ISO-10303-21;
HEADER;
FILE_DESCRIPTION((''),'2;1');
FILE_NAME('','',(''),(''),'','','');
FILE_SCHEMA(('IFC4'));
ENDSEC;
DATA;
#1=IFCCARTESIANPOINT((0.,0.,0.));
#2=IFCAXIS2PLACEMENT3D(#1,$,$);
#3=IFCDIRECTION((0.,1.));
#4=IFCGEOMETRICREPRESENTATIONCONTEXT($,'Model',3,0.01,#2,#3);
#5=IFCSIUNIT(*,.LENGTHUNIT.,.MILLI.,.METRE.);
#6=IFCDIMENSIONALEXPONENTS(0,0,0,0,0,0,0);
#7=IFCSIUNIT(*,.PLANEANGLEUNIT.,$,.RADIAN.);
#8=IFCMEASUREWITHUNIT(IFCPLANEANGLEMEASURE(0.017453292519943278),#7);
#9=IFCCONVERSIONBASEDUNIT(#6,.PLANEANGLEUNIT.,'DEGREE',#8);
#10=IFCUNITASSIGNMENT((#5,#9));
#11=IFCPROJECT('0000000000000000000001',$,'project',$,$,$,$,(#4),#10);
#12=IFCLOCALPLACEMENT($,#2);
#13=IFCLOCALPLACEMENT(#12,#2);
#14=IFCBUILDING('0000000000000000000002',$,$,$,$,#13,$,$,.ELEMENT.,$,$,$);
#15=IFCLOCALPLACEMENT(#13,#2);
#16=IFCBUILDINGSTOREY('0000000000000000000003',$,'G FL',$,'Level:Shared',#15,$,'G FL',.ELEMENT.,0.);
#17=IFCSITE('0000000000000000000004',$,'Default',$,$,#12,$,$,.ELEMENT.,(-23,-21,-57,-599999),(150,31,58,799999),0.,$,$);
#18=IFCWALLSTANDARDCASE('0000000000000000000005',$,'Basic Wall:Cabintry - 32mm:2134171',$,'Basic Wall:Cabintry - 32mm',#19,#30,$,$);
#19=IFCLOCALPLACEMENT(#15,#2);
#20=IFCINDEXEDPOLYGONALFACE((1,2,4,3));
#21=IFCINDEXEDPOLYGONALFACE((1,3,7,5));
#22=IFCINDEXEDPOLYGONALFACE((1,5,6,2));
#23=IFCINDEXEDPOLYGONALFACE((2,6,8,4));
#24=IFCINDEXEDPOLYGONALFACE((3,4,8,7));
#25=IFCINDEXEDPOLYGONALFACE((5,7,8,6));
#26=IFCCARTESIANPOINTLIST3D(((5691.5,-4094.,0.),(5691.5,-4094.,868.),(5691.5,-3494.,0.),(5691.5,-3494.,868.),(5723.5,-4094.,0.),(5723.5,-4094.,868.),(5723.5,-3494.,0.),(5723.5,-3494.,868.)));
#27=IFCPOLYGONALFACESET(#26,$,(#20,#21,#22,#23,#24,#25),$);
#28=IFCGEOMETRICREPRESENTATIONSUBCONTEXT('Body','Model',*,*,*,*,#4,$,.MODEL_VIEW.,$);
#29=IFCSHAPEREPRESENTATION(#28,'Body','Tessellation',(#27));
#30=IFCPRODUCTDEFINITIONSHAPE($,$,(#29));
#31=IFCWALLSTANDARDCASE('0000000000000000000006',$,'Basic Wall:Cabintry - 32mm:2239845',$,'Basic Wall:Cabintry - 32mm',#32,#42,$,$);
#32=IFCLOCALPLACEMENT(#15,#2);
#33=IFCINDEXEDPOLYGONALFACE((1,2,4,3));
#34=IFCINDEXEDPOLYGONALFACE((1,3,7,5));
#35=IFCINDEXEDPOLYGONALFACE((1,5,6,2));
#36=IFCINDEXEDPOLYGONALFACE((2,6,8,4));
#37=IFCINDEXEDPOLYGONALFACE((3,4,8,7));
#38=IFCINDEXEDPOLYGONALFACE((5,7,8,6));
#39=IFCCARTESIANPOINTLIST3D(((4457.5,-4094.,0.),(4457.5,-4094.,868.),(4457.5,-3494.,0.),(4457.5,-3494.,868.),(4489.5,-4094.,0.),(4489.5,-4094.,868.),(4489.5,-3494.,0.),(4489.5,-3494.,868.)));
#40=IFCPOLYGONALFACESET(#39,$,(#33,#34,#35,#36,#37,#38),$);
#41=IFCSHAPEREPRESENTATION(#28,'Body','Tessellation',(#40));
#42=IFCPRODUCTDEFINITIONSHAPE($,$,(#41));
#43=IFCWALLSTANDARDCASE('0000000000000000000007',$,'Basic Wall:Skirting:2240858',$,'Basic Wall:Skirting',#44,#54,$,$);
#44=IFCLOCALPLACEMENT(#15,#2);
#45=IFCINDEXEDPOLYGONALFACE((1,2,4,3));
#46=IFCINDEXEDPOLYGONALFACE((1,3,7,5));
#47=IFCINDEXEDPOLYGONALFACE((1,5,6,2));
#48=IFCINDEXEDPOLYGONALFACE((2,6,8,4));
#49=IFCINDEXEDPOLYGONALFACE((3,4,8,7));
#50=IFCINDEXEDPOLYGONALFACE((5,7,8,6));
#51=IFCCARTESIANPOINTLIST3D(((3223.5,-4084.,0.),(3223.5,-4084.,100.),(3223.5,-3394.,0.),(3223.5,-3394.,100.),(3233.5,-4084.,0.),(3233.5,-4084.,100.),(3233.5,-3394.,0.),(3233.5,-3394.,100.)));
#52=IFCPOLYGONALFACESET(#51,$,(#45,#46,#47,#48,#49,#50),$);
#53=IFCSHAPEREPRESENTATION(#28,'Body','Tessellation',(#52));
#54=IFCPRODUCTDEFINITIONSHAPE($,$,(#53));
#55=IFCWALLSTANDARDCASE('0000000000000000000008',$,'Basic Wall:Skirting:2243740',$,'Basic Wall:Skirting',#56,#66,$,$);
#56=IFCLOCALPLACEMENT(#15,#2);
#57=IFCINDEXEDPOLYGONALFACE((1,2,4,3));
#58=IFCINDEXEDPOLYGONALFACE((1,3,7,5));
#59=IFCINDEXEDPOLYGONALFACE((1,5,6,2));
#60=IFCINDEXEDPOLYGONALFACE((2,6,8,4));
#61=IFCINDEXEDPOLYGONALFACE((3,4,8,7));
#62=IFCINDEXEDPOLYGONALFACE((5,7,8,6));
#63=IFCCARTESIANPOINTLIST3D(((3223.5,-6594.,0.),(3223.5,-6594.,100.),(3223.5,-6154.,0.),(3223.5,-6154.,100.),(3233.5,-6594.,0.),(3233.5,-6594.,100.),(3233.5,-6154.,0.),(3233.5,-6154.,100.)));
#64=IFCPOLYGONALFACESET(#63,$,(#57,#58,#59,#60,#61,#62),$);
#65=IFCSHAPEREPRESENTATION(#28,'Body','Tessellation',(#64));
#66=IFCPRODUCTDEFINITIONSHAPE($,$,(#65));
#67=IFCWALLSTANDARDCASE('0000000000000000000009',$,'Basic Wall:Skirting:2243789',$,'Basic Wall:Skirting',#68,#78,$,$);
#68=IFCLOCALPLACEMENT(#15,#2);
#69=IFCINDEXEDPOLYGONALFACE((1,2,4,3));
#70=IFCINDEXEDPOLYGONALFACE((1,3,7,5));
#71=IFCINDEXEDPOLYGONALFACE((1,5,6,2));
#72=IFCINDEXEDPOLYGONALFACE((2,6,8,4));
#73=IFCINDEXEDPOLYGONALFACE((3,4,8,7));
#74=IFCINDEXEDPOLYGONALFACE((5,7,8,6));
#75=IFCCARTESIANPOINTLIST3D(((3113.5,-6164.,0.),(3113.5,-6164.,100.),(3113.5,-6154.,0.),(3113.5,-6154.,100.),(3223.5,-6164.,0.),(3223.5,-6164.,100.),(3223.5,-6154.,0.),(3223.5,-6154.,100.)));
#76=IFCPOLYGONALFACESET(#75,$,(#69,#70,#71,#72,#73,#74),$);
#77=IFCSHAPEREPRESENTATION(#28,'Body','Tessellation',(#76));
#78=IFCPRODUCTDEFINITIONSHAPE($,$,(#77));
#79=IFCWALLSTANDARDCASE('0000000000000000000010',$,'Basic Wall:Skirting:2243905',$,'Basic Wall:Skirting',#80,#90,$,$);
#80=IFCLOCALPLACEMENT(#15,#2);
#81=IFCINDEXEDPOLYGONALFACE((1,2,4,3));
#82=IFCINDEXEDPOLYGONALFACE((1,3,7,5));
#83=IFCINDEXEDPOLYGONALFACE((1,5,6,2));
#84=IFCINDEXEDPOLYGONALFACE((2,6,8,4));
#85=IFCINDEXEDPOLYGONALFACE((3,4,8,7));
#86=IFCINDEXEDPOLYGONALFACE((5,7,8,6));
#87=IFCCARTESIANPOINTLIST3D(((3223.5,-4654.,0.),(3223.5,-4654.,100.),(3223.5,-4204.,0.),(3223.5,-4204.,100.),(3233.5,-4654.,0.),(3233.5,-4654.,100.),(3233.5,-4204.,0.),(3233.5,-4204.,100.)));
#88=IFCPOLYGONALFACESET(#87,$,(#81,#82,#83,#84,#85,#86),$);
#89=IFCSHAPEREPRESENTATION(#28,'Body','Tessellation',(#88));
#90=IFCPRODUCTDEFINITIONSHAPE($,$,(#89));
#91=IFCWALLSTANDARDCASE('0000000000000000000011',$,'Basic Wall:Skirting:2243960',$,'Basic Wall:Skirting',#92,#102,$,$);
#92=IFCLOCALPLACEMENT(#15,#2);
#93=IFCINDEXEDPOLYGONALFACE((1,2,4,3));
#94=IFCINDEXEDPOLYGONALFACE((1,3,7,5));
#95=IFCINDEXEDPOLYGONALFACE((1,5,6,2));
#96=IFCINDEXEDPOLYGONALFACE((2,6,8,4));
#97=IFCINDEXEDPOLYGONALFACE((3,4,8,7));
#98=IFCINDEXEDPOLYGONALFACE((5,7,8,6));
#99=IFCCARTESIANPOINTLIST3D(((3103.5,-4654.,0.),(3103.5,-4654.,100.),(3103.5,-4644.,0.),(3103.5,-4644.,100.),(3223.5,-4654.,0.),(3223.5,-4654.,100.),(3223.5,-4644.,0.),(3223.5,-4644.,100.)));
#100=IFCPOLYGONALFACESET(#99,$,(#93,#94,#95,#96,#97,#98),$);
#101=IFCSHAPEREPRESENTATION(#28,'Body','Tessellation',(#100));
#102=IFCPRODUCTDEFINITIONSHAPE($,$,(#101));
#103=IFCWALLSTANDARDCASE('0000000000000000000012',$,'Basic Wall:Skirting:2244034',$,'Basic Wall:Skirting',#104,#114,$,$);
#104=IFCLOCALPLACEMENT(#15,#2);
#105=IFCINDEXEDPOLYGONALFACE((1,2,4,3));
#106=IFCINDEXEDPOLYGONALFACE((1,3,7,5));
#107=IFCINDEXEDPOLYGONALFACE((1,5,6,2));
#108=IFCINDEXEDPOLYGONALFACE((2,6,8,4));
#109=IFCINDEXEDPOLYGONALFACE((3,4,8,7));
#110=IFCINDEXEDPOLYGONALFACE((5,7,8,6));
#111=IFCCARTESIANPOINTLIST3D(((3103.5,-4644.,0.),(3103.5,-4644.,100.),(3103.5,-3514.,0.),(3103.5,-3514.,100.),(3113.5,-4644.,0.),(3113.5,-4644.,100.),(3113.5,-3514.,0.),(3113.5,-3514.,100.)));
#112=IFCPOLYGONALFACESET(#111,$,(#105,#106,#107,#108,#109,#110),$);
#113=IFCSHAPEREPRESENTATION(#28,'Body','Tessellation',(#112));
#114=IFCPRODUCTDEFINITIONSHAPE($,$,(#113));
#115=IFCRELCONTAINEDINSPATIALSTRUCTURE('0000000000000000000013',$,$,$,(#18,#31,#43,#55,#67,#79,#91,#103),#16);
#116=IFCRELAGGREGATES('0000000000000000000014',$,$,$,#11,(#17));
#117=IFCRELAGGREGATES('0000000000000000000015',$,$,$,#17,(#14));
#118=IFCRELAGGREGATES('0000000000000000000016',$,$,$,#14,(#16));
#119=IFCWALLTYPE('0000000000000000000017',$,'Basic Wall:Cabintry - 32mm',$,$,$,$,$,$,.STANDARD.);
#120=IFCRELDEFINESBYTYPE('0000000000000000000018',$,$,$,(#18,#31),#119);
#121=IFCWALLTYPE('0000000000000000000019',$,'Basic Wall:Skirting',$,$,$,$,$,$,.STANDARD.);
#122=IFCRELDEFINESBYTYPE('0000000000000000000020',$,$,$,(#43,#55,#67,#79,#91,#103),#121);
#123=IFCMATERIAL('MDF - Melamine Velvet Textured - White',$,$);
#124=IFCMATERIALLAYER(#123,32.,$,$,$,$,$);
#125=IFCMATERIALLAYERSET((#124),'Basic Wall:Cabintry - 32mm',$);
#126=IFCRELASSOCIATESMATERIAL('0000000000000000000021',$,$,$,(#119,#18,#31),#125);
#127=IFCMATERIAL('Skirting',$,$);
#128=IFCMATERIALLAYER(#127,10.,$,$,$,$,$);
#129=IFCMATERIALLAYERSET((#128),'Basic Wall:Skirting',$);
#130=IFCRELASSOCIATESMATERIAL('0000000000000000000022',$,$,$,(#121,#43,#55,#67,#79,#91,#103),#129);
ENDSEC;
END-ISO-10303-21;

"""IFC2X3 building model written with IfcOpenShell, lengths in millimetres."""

from ifc_helpers import new_model, entity, si_unit, converted_unit, direction, frame, frame_2d, origin, place, context, subcontext, project, spatial, polyline, rectangle, extrude, clip, bounded_halfspace, material, layer, layer_set, layer_usage, type_object, element, save


model = new_model("IFC2X3")

# Units and contexts
model_context = context("Model", 3, precision=0.01, world=origin(), true_north=direction((0.0, 1.0)))
body_context = subcontext(model_context, "Body", "Model", "MODEL_VIEW")
ifc_project = project(units=[si_unit("LENGTHUNIT", "METRE", prefix="MILLI"), converted_unit("PLANEANGLEUNIT", "DEGREE", entity("IfcPlaneAngleMeasure", 0.017453292519943278), si_unit("PLANEANGLEUNIT", "RADIAN"), dimensions=[0, 0, 0, 0, 0, 0, 0])], contexts=[model_context])

# Site, building, storey
site_placement = place(None, origin())
site = spatial("IfcSite", under=ifc_project, at=site_placement, Name="Default", CompositionType="ELEMENT", RefLatitude=(-23, -21, -57, -599999), RefLongitude=(150, 31, 58, 799999), RefElevation=0.0)
building_placement = place(site_placement, origin())
building = spatial("IfcBuilding", under=site, at=building_placement, CompositionType="ELEMENT")
storey_placement = place(building_placement, origin())
storey = spatial("IfcBuildingStorey", under=building, at=storey_placement, Name="G FL", ObjectType="Level:Shared", LongName="G FL", CompositionType="ELEMENT", Elevation=0.0)

# Shared definitions
ifc_material_1 = material(Name="MDF - Melamine Velvet Textured - White")

# Walls
ifc_layer_1 = layer(ifc_material_1, 32.0)
ifc_layer_set_1 = layer_set([ifc_layer_1], Name="Basic Wall:Cabintry - 32mm")
ifc_layer_usage_1 = layer_usage(ifc_layer_set_1, "AXIS2", "POSITIVE", -16.0)
wall_type_1 = type_object("IfcWallType", Name="Basic Wall:Cabintry - 32mm", PredefinedType="STANDARD", material=ifc_layer_set_1)
wall_1_placement = place(storey_placement, frame((5707.5, -4094.0, 0.0), z_axis=(0.0, 0.0, 1.0), x_axis=(0.0, 1.0, 0.0)))
element("IfcWallStandardCase", 1, at=wall_1_placement, inside=storey, type_object=wall_type_1, material=ifc_layer_usage_1, Name="Basic Wall:Cabintry - 32mm:2134171", ObjectType="Basic Wall:Cabintry - 32mm", context=body_context, shape_type="Clipping", body=[
    clip(extrude(rectangle(XDim=600.0, YDim=32.0, at=frame_2d((300.0, 0.0), x_axis=(-1.0, 0.0))), origin(), (0.0, 0.0, 1.0), 868.0), bounded_halfspace(frame((0.0, -16.0, 868.0), z_axis=(0.0, 0.0, -1.0), x_axis=(-1.0, 0.0, 0.0)), True, frame((0.0, -16.0, 868.0)), polyline([(0.0, 0.0), (600.0, 0.0), (600.0, 32.0), (0.0, 32.0), (0.0, 0.0)]))),
])
ifc_layer_usage_2 = layer_usage(ifc_layer_set_1, "AXIS2", "POSITIVE", -16.0)
wall_2_placement = place(storey_placement, frame((4473.5, -4094.0, 0.0), z_axis=(0.0, 0.0, 1.0), x_axis=(0.0, 1.0, 0.0)))
element("IfcWallStandardCase", 2, at=wall_2_placement, inside=storey, type_object=wall_type_1, material=ifc_layer_usage_2, Name="Basic Wall:Cabintry - 32mm:2239845", ObjectType="Basic Wall:Cabintry - 32mm", context=body_context, shape_type="Clipping", body=[
    clip(extrude(rectangle(XDim=600.0, YDim=32.0, at=frame_2d((300.0, 0.0), x_axis=(-1.0, 0.0))), origin(), (0.0, 0.0, 1.0), 868.0), bounded_halfspace(frame((0.0, -16.0, 868.0), z_axis=(0.0, 0.0, -1.0), x_axis=(-1.0, 0.0, 0.0)), True, frame((0.0, -16.0, 868.0)), polyline([(0.0, 0.0), (600.0, 0.0), (600.0, 32.0), (0.0, 32.0), (0.0, 0.0)]))),
])
ifc_material_2 = material(Name="Skirting")
ifc_layer_2 = layer(ifc_material_2, 10.0)
ifc_layer_set_2 = layer_set([ifc_layer_2], Name="Basic Wall:Skirting")
ifc_layer_usage_3 = layer_usage(ifc_layer_set_2, "AXIS2", "NEGATIVE", 5.0)
wall_type_2 = type_object("IfcWallType", Name="Basic Wall:Skirting", PredefinedType="STANDARD", material=ifc_layer_set_2)
wall_3_placement = place(storey_placement, frame((3228.5, -4084.0, 0.0), z_axis=(0.0, 0.0, 1.0), x_axis=(0.0, 1.0, 0.0)))
element("IfcWallStandardCase", 3, at=wall_3_placement, inside=storey, type_object=wall_type_2, material=ifc_layer_usage_3, Name="Basic Wall:Skirting:2240858", ObjectType="Basic Wall:Skirting", context=body_context, shape_type="SweptSolid", body=[
    extrude(rectangle(XDim=690.0, YDim=10.0, at=frame_2d((345.0, 0.0), x_axis=(-1.0, 0.0))), origin(), (0.0, 0.0, 1.0), 100.0),
])

# Walls
ifc_layer_usage_4 = layer_usage(ifc_layer_set_2, "AXIS2", "NEGATIVE", 5.0)
wall_4_placement = place(storey_placement, frame((3228.5, -6594.0, 0.0), z_axis=(0.0, 0.0, 1.0), x_axis=(0.0, 1.0, 0.0)))
element("IfcWallStandardCase", 4, at=wall_4_placement, inside=storey, type_object=wall_type_2, material=ifc_layer_usage_4, Name="Basic Wall:Skirting:2243740", ObjectType="Basic Wall:Skirting", context=body_context, shape_type="SweptSolid", body=[
    extrude(rectangle(XDim=440.0, YDim=10.0, at=frame_2d((220.0, 0.0), x_axis=(-1.0, 0.0))), origin(), (0.0, 0.0, 1.0), 100.0),
])
ifc_layer_usage_5 = layer_usage(ifc_layer_set_2, "AXIS2", "NEGATIVE", 5.0)
wall_5_placement = place(storey_placement, frame((3223.5, -6159.0, 0.0), z_axis=(0.0, 0.0, 1.0), x_axis=(-1.0, 0.0, 0.0)))
element("IfcWallStandardCase", 5, at=wall_5_placement, inside=storey, type_object=wall_type_2, material=ifc_layer_usage_5, Name="Basic Wall:Skirting:2243789", ObjectType="Basic Wall:Skirting", context=body_context, shape_type="SweptSolid", body=[
    extrude(rectangle(XDim=110.0, YDim=10.0, at=frame_2d((55.0, 0.0), x_axis=(-1.0, 0.0))), origin(), (0.0, 0.0, 1.0), 100.0),
])
ifc_layer_usage_6 = layer_usage(ifc_layer_set_2, "AXIS2", "NEGATIVE", 5.0)
wall_6_placement = place(storey_placement, frame((3228.5, -4204.0, 0.0), z_axis=(0.0, 0.0, 1.0), x_axis=(0.0, -1.0, 0.0)))
element("IfcWallStandardCase", 6, at=wall_6_placement, inside=storey, type_object=wall_type_2, material=ifc_layer_usage_6, Name="Basic Wall:Skirting:2243905", ObjectType="Basic Wall:Skirting", context=body_context, shape_type="SweptSolid", body=[
    extrude(rectangle(XDim=450.0, YDim=10.0, at=frame_2d((225.0, 0.0), x_axis=(-1.0, 0.0))), origin(), (0.0, 0.0, 1.0), 100.0),
])
ifc_layer_usage_7 = layer_usage(ifc_layer_set_2, "AXIS2", "NEGATIVE", 5.0)
wall_7_placement = place(storey_placement, frame((3223.5, -4649.0, 0.0), z_axis=(0.0, 0.0, 1.0), x_axis=(-1.0, 0.0, 0.0)))
element("IfcWallStandardCase", 7, at=wall_7_placement, inside=storey, type_object=wall_type_2, material=ifc_layer_usage_7, Name="Basic Wall:Skirting:2243960", ObjectType="Basic Wall:Skirting", context=body_context, shape_type="SweptSolid", body=[
    extrude(rectangle(XDim=120.0, YDim=10.0, at=frame_2d((60.0, 0.0), x_axis=(-1.0, 0.0))), origin(), (0.0, 0.0, 1.0), 100.0),
])
ifc_layer_usage_8 = layer_usage(ifc_layer_set_2, "AXIS2", "NEGATIVE", 5.0)
wall_8_placement = place(storey_placement, frame((3108.5, -4644.0, 0.0), z_axis=(0.0, 0.0, 1.0), x_axis=(0.0, 1.0, 0.0)))
element("IfcWallStandardCase", 8, at=wall_8_placement, inside=storey, type_object=wall_type_2, material=ifc_layer_usage_8, Name="Basic Wall:Skirting:2244034", ObjectType="Basic Wall:Skirting", context=body_context, shape_type="SweptSolid", body=[
    extrude(rectangle(XDim=1130.0, YDim=10.0, at=frame_2d((565.0, 0.0), x_axis=(-1.0, 0.0))), origin(), (0.0, 0.0, 1.0), 100.0),
])

save(model, "model.ifc")
